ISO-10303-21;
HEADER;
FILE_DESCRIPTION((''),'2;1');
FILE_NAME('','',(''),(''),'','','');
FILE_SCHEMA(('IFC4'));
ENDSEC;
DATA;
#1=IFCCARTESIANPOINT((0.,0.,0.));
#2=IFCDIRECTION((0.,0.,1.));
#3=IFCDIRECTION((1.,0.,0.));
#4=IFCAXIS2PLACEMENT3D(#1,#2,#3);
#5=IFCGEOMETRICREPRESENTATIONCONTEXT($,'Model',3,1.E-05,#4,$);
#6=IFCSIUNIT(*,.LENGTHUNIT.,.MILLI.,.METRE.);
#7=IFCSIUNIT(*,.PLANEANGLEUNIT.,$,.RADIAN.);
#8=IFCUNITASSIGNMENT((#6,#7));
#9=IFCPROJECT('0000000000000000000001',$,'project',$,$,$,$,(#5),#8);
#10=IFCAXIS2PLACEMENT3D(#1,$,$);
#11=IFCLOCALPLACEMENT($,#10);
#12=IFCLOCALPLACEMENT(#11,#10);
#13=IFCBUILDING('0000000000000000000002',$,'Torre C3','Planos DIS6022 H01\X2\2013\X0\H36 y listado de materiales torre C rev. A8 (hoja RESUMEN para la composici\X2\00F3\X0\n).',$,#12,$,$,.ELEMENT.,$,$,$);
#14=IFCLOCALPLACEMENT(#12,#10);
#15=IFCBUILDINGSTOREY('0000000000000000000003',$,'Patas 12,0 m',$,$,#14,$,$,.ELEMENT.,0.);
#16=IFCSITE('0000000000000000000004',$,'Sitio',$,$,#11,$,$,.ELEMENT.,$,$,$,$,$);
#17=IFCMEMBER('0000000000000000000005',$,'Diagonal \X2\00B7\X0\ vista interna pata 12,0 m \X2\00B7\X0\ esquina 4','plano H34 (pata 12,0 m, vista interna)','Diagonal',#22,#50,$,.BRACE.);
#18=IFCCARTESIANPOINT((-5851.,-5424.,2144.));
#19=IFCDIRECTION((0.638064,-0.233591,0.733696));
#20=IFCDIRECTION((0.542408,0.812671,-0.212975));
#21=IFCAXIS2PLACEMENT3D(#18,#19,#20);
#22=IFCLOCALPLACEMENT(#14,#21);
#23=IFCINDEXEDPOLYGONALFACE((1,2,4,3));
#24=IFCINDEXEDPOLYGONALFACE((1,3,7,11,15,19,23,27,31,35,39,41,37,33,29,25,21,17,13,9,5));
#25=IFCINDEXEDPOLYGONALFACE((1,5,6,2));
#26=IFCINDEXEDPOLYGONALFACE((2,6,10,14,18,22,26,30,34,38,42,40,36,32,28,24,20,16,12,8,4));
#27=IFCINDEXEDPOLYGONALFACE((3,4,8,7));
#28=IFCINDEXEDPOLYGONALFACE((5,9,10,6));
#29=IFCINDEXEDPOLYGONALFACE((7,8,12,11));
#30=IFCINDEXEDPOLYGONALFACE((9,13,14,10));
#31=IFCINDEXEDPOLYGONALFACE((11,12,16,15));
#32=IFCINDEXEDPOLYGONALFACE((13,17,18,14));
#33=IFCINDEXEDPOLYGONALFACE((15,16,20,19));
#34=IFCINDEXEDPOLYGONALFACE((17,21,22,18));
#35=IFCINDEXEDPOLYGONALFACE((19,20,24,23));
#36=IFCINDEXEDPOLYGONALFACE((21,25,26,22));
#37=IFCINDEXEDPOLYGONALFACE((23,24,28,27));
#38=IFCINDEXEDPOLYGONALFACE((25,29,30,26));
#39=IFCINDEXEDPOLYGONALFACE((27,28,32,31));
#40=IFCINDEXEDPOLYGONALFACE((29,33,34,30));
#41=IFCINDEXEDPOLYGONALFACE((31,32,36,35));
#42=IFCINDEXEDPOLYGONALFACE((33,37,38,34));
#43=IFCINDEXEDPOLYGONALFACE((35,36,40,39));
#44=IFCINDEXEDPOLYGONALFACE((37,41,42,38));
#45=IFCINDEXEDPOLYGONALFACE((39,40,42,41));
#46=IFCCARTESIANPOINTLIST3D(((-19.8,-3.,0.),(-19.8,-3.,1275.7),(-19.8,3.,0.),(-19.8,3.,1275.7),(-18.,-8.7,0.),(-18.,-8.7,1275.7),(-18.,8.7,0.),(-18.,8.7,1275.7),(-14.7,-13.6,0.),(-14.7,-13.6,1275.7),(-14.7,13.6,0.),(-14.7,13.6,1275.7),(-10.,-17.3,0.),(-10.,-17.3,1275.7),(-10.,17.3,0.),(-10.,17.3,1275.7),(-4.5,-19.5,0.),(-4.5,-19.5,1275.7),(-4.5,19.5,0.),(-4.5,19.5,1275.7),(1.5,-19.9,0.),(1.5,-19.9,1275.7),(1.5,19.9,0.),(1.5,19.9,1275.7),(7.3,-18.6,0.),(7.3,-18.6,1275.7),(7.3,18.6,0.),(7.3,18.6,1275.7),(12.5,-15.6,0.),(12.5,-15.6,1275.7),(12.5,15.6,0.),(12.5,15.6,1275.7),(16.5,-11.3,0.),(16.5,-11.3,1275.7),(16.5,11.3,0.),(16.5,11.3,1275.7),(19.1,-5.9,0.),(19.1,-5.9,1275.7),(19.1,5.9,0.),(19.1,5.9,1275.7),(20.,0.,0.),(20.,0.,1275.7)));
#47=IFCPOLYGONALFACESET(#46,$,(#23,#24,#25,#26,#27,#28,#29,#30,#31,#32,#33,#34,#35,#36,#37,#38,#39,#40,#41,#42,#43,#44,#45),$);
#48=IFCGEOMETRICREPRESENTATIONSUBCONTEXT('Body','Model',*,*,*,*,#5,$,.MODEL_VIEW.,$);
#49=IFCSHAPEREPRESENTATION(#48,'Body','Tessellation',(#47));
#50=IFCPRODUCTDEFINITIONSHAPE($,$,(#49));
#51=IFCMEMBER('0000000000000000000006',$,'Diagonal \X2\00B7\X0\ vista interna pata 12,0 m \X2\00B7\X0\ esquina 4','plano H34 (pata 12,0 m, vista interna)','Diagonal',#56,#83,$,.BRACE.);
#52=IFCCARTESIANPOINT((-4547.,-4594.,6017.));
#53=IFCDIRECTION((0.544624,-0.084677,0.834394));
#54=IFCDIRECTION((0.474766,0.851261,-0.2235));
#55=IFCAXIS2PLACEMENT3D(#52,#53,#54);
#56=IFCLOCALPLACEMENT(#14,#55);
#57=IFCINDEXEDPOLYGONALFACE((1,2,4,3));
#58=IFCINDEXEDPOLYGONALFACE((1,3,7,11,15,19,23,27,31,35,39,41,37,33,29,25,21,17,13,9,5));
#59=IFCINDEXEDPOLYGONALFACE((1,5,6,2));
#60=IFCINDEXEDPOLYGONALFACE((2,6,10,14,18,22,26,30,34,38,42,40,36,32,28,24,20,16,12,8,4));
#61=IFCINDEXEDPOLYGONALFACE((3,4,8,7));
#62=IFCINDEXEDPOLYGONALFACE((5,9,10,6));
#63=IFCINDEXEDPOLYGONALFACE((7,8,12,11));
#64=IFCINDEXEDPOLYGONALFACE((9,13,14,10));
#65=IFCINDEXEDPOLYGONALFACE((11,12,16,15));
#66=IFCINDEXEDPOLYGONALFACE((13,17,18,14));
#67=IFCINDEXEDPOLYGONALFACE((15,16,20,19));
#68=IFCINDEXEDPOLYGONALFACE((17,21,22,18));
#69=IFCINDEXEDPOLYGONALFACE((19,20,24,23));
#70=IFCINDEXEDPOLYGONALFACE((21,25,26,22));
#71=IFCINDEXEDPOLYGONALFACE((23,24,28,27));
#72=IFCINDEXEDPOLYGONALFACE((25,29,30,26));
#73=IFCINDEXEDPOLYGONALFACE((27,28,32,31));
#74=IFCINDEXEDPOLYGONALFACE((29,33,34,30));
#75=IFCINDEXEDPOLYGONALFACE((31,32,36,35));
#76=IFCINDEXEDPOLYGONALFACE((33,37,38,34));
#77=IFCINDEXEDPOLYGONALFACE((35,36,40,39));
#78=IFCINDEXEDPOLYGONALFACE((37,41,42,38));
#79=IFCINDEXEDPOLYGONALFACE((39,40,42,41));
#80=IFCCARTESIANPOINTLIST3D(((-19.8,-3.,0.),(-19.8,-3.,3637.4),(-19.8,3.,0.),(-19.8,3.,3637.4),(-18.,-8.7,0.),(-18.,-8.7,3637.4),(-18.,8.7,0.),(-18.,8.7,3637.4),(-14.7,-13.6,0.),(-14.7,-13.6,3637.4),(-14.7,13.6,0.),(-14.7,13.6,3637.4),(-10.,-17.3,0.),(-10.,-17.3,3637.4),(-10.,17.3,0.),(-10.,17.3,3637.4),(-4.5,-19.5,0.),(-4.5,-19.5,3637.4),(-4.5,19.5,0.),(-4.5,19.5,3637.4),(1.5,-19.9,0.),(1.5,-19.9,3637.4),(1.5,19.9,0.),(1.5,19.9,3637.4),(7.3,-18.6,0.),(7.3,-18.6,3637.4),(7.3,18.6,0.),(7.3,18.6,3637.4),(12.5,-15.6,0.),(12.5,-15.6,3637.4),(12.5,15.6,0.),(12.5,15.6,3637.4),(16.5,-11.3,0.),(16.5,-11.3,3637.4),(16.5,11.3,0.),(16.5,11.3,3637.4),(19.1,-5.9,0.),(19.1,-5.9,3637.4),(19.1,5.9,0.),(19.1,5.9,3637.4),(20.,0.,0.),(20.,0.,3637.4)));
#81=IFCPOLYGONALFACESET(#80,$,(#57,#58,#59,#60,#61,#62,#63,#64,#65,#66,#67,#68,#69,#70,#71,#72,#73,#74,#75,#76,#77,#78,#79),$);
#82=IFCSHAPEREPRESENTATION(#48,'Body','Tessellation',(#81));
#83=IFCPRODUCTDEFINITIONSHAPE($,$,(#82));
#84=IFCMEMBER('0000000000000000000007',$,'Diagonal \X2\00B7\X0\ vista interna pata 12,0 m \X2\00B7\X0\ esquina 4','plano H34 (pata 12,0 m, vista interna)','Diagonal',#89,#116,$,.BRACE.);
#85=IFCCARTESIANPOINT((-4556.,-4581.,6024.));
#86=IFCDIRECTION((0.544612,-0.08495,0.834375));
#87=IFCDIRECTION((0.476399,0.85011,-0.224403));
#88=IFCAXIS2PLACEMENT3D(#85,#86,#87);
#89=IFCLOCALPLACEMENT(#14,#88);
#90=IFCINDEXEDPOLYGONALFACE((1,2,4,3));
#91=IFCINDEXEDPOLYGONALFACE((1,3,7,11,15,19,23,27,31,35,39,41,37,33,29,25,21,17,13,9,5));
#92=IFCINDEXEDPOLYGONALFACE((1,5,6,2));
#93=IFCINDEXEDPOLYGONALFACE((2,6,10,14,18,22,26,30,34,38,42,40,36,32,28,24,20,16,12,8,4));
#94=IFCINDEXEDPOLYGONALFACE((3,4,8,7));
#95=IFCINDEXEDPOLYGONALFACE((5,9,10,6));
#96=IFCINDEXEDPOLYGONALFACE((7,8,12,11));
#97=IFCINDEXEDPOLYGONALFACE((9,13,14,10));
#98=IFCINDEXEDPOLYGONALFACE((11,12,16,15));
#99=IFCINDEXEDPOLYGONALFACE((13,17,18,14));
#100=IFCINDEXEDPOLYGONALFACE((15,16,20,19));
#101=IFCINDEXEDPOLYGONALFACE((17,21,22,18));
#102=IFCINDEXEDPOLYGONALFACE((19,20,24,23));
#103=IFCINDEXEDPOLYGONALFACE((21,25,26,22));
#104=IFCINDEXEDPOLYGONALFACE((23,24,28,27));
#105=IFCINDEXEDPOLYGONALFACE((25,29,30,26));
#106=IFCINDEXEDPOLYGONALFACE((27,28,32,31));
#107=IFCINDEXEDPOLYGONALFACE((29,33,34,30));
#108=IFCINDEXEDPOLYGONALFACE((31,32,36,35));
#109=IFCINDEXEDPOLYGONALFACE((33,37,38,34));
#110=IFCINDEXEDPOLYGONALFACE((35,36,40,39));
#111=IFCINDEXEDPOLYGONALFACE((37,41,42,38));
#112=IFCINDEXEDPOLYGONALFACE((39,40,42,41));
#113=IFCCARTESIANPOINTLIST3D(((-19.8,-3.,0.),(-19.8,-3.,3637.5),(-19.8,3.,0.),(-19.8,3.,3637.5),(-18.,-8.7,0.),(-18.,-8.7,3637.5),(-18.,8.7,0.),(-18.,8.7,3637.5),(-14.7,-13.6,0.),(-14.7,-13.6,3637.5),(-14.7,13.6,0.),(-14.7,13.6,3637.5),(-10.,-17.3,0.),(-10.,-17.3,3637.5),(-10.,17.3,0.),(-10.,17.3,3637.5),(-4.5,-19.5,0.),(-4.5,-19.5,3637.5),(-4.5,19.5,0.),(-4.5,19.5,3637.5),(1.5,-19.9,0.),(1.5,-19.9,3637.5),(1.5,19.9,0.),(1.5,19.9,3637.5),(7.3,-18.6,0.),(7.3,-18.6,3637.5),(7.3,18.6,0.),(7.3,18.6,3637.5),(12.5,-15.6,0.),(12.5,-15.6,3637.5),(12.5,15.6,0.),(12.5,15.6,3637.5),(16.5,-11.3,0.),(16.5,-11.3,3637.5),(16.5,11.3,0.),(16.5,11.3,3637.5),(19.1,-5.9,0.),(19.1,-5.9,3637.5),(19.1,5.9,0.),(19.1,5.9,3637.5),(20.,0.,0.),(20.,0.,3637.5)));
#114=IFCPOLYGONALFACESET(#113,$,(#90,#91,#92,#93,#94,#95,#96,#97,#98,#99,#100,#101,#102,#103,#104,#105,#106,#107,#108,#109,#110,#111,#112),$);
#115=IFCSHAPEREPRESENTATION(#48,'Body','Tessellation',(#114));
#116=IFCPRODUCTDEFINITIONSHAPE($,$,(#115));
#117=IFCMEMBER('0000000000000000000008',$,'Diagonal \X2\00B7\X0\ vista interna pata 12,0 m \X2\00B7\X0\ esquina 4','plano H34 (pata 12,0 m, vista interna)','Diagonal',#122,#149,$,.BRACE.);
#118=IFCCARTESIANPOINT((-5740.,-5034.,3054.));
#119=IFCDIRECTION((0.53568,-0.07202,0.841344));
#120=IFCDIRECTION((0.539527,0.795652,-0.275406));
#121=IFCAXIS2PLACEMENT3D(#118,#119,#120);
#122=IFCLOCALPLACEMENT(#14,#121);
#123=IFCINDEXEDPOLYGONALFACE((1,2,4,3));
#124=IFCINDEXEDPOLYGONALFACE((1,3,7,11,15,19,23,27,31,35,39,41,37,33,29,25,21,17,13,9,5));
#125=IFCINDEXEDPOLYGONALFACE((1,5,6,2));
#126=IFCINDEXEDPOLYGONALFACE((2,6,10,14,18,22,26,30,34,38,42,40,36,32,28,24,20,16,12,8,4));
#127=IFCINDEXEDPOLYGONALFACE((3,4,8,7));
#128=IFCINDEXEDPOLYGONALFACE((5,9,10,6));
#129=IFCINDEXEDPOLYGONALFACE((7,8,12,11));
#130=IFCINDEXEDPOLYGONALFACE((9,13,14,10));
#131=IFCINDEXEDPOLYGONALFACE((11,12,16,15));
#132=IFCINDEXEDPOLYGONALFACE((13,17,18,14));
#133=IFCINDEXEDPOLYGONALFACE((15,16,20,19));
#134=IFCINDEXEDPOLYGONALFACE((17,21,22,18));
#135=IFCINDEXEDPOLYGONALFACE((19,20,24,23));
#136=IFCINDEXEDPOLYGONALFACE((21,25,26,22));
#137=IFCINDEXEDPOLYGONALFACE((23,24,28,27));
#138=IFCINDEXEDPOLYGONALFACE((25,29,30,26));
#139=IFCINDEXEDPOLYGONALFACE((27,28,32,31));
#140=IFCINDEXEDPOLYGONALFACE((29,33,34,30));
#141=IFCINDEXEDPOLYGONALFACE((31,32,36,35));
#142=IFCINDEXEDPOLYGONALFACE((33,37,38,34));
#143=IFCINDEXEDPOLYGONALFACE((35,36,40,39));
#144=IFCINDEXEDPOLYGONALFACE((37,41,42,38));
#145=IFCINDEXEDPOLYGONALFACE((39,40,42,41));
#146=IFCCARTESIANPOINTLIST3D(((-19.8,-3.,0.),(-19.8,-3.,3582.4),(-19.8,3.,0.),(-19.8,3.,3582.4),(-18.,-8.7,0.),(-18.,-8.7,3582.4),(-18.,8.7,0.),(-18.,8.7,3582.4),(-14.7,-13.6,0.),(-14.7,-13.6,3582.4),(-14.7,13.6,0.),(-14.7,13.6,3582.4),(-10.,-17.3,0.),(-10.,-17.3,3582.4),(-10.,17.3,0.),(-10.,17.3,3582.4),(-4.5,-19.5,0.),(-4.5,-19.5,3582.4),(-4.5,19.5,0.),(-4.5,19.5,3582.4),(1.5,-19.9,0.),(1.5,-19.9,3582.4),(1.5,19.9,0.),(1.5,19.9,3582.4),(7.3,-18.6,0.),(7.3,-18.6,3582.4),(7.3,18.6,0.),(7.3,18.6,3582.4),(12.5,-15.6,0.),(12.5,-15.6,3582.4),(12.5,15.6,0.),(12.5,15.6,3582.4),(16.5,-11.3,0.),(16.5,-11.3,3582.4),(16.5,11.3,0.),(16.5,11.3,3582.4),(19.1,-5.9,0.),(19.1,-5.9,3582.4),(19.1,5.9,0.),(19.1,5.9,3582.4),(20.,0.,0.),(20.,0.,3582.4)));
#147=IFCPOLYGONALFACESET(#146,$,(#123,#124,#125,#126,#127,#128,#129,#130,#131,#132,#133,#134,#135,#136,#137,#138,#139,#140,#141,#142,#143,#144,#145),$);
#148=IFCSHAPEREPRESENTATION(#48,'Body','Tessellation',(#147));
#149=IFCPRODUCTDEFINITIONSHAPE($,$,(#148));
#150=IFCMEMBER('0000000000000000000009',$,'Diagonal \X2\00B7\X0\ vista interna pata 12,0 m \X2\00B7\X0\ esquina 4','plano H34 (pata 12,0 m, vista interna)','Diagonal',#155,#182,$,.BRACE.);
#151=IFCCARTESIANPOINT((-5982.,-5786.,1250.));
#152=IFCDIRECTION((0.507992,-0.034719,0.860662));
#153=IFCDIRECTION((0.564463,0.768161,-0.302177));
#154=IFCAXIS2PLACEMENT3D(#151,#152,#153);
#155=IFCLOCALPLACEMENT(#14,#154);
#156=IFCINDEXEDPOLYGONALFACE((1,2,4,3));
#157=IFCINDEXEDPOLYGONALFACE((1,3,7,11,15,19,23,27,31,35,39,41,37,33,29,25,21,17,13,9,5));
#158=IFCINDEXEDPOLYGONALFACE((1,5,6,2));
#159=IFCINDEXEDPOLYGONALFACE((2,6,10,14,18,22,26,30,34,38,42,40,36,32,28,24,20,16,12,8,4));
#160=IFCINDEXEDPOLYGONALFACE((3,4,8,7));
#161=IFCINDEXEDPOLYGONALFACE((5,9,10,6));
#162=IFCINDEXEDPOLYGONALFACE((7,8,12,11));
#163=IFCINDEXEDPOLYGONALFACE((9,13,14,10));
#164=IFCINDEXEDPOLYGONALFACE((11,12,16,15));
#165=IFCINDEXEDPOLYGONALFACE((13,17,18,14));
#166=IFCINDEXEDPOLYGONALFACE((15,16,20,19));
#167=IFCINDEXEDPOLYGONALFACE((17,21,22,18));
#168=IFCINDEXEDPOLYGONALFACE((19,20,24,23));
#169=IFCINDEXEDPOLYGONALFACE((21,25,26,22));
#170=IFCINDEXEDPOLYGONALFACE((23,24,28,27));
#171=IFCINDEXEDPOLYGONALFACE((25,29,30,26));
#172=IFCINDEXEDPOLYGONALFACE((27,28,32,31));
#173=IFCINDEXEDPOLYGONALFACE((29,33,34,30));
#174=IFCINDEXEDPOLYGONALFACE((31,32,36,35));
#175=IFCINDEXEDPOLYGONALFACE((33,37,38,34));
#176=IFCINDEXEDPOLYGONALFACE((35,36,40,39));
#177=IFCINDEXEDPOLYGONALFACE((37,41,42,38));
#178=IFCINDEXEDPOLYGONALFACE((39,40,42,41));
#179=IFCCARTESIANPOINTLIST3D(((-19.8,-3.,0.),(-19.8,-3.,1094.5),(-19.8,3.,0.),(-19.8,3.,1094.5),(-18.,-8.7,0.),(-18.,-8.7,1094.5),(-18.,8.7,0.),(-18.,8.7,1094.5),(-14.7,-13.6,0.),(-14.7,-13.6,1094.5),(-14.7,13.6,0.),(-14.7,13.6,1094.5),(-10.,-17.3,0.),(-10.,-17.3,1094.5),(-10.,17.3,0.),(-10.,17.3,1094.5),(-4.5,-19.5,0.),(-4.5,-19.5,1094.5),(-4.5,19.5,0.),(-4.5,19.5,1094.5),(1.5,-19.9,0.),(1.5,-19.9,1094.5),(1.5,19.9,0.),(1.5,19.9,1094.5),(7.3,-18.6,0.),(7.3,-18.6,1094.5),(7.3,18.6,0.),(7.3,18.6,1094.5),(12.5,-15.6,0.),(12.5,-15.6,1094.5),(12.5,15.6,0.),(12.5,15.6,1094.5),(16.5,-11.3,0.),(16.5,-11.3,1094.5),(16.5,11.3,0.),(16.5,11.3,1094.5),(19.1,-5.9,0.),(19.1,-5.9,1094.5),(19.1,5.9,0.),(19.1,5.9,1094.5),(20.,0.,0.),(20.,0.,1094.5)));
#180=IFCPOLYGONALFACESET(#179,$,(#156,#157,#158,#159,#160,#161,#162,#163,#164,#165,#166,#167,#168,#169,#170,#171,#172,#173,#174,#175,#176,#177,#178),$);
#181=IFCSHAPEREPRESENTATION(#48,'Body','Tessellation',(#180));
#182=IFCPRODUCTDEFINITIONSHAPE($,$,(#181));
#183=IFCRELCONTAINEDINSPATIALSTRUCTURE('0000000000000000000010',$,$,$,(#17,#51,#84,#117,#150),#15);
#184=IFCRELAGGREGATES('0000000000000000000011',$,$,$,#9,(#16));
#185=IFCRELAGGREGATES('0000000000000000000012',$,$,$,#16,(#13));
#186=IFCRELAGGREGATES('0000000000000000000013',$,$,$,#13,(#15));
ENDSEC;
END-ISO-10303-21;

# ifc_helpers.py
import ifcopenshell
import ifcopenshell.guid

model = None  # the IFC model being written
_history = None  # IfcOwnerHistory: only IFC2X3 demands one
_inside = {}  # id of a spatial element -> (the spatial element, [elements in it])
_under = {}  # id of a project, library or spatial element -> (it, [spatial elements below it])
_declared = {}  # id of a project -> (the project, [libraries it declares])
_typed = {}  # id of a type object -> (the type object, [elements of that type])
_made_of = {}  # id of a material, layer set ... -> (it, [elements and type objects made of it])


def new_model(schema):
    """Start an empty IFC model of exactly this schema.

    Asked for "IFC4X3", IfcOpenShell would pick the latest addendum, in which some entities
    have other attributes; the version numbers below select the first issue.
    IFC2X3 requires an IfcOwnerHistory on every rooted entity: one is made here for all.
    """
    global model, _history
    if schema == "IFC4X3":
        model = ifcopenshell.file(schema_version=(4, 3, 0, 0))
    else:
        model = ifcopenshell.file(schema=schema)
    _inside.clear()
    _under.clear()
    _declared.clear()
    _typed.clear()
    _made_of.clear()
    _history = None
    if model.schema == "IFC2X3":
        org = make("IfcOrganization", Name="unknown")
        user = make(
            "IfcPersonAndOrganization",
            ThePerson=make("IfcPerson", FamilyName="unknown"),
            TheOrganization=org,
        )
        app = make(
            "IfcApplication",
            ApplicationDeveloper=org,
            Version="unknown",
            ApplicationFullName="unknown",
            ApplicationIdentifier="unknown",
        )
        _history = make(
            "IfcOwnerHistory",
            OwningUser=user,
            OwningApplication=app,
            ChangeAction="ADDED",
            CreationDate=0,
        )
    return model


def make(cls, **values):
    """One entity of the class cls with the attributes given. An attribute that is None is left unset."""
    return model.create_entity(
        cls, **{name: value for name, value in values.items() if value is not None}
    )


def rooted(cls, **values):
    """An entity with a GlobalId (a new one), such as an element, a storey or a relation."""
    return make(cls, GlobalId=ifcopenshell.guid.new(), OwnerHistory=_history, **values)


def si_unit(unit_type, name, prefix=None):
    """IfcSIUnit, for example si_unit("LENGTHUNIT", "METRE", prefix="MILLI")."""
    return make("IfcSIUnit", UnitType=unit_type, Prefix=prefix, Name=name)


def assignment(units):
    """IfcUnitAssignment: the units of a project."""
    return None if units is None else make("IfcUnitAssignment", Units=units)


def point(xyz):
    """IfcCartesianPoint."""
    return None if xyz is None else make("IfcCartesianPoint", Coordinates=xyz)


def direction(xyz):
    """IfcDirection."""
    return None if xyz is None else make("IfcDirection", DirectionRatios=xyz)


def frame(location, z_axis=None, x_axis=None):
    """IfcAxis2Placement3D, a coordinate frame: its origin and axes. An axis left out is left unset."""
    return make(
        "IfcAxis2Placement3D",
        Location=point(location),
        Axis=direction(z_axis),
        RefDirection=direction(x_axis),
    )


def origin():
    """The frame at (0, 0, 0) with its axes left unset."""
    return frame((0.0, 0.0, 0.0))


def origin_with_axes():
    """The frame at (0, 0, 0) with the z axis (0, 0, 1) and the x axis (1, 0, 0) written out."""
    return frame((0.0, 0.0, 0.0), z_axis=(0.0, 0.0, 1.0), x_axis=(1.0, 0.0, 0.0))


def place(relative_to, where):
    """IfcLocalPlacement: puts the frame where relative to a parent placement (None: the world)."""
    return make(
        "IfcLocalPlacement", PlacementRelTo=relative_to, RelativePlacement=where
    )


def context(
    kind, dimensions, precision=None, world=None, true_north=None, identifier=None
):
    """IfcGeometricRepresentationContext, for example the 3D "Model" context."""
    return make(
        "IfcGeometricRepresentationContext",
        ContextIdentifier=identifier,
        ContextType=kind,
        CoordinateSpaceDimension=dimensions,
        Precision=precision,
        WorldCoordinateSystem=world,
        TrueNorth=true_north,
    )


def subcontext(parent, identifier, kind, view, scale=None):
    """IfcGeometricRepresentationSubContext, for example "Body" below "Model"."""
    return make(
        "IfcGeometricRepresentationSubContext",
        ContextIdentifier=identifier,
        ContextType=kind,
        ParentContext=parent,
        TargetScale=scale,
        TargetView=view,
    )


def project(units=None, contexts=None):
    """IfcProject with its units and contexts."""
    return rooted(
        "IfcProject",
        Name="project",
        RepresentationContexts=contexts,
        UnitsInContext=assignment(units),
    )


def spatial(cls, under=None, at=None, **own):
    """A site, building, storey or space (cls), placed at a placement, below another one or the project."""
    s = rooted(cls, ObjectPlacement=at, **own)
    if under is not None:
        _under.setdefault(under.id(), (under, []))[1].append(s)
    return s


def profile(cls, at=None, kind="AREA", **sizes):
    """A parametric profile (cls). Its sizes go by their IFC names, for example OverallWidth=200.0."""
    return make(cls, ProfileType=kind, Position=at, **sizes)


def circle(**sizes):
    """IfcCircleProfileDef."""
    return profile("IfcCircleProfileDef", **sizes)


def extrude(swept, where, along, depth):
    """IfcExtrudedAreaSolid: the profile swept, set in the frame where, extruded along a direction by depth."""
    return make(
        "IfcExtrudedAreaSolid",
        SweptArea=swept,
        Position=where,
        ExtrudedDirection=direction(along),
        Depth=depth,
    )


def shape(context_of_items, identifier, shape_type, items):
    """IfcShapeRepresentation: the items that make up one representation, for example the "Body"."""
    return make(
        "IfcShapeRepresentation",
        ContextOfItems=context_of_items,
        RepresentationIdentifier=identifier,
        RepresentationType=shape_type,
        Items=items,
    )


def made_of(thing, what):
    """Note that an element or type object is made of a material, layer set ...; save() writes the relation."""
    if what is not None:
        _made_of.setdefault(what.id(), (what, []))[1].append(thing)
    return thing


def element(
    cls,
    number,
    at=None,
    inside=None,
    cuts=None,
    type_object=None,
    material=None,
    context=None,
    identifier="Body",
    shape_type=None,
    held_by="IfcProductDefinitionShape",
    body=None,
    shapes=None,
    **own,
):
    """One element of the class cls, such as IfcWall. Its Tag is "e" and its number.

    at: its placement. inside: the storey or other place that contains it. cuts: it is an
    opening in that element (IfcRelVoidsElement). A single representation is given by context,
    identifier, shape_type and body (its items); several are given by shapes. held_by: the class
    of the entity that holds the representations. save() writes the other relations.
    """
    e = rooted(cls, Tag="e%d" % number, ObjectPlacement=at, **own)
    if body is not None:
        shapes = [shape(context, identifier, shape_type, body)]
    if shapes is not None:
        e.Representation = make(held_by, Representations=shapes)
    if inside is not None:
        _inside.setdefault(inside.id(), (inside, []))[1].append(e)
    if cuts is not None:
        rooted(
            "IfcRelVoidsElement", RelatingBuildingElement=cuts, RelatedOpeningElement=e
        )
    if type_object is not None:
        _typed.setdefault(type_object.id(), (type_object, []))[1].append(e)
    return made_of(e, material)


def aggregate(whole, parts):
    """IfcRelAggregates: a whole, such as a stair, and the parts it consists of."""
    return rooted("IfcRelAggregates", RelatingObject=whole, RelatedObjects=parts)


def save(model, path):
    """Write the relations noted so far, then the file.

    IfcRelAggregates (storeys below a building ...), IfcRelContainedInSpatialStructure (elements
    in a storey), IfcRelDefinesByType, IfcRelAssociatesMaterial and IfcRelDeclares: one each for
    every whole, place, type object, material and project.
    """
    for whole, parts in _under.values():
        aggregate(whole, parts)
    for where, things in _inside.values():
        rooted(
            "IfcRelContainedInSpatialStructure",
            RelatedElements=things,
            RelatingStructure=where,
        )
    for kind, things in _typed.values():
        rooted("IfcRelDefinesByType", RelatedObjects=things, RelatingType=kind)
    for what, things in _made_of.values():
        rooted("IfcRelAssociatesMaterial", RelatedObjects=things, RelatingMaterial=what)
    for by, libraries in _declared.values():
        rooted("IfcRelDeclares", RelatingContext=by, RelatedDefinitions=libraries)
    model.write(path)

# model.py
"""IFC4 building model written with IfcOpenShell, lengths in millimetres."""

from ifc_helpers import new_model, si_unit, frame, origin, origin_with_axes, place, context, subcontext, project, spatial, circle, extrude, element, save


model = new_model("IFC4")

# Units and contexts
model_context = context("Model", 3, precision=1e-05, world=origin_with_axes())
body_context = subcontext(model_context, "Body", "Model", "MODEL_VIEW")
ifc_project = project(units=[si_unit("LENGTHUNIT", "METRE", prefix="MILLI"), si_unit("PLANEANGLEUNIT", "RADIAN")], contexts=[model_context])

# Site, building, storey
site_placement = place(None, origin())
site = spatial("IfcSite", under=ifc_project, at=site_placement, Name="Sitio", CompositionType="ELEMENT")
building_placement = place(site_placement, origin())
building = spatial("IfcBuilding", under=site, at=building_placement, Name="Torre C3", Description="Planos DIS6022 H01–H36 y listado de materiales torre C rev. A8 (hoja RESUMEN para la composición).", CompositionType="ELEMENT")
storey_placement = place(building_placement, origin())
storey = spatial("IfcBuildingStorey", under=building, at=storey_placement, Name="Patas 12,0 m", CompositionType="ELEMENT", Elevation=0.0)

# Members
member_1_placement = place(storey_placement, frame((-5851.0, -5424.0, 2144.0), z_axis=(0.638064, -0.233591, 0.733696), x_axis=(0.542408, 0.812671, -0.212975)))
element("IfcMember", 1, at=member_1_placement, inside=storey, Name="Diagonal · vista interna pata 12,0 m · esquina 4", Description="plano H34 (pata 12,0 m, vista interna)", ObjectType="Diagonal", PredefinedType="BRACE", context=body_context, shape_type="SweptSolid", body=[
    extrude(circle(Radius=20.0), None, (0.0, 0.0, 1.0), 1275.7),
])
member_2_placement = place(storey_placement, frame((-4547.0, -4594.0, 6017.0), z_axis=(0.544624, -0.084677, 0.834394), x_axis=(0.474766, 0.851261, -0.2235)))
element("IfcMember", 2, at=member_2_placement, inside=storey, Name="Diagonal · vista interna pata 12,0 m · esquina 4", Description="plano H34 (pata 12,0 m, vista interna)", ObjectType="Diagonal", PredefinedType="BRACE", context=body_context, shape_type="SweptSolid", body=[
    extrude(circle(Radius=20.0), None, (0.0, 0.0, 1.0), 3637.4),
])
member_3_placement = place(storey_placement, frame((-4556.0, -4581.0, 6024.0), z_axis=(0.544612, -0.08495, 0.834375), x_axis=(0.476399, 0.85011, -0.224403)))
element("IfcMember", 3, at=member_3_placement, inside=storey, Name="Diagonal · vista interna pata 12,0 m · esquina 4", Description="plano H34 (pata 12,0 m, vista interna)", ObjectType="Diagonal", PredefinedType="BRACE", context=body_context, shape_type="SweptSolid", body=[
    extrude(circle(Radius=20.0), None, (0.0, 0.0, 1.0), 3637.5),
])
member_4_placement = place(storey_placement, frame((-5740.0, -5034.0, 3054.0), z_axis=(0.53568, -0.07202, 0.841344), x_axis=(0.539527, 0.795652, -0.275406)))
element("IfcMember", 4, at=member_4_placement, inside=storey, Name="Diagonal · vista interna pata 12,0 m · esquina 4", Description="plano H34 (pata 12,0 m, vista interna)", ObjectType="Diagonal", PredefinedType="BRACE", context=body_context, shape_type="SweptSolid", body=[
    extrude(circle(Radius=20.0), None, (0.0, 0.0, 1.0), 3582.4),
])
member_5_placement = place(storey_placement, frame((-5982.0, -5786.0, 1250.0), z_axis=(0.507992, -0.034719, 0.860662), x_axis=(0.564463, 0.768161, -0.302177)))
element("IfcMember", 5, at=member_5_placement, inside=storey, Name="Diagonal · vista interna pata 12,0 m · esquina 4", Description="plano H34 (pata 12,0 m, vista interna)", ObjectType="Diagonal", PredefinedType="BRACE", context=body_context, shape_type="SweptSolid", body=[
    extrude(circle(Radius=20.0), None, (0.0, 0.0, 1.0), 1094.5),
])

save(model, "model.ifc")
